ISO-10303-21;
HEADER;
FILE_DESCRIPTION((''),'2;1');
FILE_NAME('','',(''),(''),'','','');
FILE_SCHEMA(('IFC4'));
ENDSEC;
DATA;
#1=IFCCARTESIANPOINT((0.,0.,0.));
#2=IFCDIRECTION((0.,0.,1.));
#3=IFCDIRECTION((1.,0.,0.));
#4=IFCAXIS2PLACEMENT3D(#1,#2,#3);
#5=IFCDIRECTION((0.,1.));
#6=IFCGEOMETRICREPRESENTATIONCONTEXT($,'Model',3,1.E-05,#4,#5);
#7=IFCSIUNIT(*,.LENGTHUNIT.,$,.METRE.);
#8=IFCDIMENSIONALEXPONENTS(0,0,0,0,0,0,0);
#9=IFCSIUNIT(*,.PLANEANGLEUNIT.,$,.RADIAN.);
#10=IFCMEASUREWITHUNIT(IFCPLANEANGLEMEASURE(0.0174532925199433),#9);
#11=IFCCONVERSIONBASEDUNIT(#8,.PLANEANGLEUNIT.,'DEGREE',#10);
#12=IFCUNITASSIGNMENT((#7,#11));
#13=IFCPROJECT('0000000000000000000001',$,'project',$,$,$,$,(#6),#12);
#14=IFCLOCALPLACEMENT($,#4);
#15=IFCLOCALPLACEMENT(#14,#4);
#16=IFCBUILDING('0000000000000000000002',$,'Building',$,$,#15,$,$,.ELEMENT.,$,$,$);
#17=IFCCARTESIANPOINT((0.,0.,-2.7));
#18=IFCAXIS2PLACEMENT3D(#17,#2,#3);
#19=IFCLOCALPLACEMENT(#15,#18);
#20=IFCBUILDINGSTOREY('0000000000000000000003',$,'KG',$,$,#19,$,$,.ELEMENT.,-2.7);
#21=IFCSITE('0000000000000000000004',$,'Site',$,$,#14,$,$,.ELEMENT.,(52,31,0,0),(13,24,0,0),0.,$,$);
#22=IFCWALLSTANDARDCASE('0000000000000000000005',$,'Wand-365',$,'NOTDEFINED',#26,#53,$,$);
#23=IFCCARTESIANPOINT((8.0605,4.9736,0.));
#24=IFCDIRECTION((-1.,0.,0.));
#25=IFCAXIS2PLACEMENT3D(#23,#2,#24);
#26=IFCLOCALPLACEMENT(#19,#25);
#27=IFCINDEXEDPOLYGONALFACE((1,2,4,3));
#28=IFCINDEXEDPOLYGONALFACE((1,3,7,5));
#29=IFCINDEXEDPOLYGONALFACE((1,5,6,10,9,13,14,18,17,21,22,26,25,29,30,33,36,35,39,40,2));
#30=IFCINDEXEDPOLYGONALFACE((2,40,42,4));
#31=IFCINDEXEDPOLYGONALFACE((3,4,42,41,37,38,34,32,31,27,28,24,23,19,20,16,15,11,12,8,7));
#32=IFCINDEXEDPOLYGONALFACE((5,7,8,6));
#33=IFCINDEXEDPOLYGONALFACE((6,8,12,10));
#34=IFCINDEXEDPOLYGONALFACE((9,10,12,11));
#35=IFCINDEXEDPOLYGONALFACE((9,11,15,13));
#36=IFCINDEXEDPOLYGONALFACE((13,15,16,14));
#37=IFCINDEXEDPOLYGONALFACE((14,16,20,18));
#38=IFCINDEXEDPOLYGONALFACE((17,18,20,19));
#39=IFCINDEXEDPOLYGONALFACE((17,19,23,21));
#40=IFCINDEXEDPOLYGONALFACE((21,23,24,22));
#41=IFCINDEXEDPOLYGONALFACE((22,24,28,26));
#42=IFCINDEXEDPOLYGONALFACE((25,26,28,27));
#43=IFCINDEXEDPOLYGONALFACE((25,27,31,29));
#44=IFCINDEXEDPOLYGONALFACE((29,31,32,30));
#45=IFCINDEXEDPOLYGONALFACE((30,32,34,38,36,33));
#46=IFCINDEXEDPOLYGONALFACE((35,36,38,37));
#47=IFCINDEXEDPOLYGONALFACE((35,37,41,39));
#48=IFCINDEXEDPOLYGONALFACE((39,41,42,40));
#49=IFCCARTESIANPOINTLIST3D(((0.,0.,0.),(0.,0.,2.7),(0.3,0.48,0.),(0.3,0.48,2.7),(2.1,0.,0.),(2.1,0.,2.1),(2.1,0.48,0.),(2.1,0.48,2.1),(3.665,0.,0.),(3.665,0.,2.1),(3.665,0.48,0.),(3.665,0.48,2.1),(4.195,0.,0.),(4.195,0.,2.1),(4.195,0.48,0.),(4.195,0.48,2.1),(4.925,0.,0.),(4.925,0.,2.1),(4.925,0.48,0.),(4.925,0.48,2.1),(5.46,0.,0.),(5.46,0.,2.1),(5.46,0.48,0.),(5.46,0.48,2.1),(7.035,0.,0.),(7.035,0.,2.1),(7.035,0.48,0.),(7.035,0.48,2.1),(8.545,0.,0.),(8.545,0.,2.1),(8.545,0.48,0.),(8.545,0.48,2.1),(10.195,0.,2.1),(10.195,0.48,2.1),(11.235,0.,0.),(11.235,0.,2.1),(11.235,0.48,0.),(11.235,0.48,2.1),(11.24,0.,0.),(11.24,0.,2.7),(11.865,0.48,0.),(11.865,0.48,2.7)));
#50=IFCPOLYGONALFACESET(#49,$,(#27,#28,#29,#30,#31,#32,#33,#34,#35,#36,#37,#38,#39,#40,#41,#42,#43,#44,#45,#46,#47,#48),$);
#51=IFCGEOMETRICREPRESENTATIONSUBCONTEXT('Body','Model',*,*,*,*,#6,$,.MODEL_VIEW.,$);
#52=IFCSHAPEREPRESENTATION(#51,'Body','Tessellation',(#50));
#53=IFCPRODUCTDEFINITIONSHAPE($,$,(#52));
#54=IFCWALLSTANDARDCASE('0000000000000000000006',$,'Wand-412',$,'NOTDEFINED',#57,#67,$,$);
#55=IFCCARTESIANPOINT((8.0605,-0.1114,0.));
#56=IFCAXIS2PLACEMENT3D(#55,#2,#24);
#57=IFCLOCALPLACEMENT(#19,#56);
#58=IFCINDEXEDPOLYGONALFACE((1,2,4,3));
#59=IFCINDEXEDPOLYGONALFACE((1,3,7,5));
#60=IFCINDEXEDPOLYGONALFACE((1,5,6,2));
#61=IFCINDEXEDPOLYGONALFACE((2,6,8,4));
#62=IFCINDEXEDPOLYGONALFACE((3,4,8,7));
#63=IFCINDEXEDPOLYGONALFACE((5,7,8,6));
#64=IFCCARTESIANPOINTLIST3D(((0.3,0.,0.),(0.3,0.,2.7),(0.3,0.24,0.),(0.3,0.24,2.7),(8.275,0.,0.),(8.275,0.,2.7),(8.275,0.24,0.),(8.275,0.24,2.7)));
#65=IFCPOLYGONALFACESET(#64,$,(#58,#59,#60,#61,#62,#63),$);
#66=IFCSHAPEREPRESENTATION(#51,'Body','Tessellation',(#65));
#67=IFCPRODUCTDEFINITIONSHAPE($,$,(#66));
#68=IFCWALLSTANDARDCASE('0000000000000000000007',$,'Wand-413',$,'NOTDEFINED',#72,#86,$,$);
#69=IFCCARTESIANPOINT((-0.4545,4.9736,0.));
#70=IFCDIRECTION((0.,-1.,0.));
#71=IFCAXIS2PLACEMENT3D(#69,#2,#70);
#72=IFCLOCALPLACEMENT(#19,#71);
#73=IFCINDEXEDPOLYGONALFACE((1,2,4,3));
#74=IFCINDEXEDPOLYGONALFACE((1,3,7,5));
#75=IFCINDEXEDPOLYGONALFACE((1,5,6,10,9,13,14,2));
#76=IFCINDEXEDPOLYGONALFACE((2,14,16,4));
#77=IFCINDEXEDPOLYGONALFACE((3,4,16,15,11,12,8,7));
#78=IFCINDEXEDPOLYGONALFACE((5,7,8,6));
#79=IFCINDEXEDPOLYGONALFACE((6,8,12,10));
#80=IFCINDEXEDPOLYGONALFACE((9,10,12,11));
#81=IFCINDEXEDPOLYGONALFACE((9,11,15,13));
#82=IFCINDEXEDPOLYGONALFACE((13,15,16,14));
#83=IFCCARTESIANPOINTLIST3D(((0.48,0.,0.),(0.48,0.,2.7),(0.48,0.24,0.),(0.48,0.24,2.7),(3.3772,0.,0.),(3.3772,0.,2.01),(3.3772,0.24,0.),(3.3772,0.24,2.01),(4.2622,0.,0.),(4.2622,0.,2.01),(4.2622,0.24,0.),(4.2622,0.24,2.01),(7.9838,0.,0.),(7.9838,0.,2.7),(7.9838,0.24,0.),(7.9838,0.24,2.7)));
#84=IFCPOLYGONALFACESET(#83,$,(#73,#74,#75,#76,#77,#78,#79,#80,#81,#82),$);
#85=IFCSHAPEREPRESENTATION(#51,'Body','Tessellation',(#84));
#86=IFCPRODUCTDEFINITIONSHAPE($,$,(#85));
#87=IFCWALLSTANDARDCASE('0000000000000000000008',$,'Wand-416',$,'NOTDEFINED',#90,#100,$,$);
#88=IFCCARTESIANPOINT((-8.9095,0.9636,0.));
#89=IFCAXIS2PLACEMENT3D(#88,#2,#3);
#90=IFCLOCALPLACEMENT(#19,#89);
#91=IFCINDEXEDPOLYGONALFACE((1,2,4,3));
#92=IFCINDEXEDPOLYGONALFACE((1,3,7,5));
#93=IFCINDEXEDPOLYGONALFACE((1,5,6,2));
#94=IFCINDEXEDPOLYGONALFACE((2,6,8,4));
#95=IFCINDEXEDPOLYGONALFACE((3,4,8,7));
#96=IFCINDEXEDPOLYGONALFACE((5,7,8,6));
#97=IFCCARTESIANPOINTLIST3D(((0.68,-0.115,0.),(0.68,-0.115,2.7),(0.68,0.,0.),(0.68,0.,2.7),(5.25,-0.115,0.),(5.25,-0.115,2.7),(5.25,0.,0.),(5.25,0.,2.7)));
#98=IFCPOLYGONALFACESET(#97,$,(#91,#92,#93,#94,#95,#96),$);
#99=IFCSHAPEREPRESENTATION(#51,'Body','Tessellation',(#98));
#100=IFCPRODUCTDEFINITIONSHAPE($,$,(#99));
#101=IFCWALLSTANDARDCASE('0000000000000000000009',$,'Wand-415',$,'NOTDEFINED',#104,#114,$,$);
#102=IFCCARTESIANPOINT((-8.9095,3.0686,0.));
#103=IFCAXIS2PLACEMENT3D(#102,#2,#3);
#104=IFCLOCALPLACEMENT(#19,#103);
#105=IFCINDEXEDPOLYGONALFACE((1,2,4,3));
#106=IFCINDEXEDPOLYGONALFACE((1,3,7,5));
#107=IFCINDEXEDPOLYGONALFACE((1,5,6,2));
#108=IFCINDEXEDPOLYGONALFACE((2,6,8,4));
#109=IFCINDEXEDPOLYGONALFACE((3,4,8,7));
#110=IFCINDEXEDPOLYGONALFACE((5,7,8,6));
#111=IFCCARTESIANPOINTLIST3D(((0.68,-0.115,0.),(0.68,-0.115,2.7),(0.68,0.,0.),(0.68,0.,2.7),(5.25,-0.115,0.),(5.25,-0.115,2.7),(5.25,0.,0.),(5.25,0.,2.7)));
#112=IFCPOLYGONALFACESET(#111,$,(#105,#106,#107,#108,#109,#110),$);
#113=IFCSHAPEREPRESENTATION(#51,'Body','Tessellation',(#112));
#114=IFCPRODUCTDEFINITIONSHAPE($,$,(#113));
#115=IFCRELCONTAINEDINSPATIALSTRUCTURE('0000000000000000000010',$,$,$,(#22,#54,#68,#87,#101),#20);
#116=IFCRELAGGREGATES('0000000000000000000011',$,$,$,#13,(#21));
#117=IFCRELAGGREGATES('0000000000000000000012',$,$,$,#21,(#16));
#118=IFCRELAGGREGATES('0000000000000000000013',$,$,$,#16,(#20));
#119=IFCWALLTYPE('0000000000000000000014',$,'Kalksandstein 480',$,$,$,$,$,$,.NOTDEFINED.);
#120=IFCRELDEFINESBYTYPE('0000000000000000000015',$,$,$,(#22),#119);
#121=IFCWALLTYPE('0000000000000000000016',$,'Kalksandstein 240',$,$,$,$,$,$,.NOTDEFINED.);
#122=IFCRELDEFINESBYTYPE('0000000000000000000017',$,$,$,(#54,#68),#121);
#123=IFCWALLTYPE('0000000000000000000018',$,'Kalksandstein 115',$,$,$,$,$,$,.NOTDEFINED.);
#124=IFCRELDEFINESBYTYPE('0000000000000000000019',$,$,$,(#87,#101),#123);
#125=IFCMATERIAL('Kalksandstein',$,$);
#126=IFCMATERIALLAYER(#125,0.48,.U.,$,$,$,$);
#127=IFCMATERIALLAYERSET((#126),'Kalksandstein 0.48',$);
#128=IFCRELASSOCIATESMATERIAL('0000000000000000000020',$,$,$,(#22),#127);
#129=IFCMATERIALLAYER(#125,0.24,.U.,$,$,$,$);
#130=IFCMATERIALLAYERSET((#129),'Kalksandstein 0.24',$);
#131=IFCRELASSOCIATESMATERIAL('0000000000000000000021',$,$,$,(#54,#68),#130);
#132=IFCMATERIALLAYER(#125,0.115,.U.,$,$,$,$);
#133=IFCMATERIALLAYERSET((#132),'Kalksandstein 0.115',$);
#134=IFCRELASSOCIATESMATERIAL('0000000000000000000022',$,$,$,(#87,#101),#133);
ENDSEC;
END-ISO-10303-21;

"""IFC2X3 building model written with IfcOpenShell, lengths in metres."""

from ifc_helpers import new_model, entity, si_unit, converted_unit, direction, frame, origin_with_axes, origin_2d_with_axis, place, context, subcontext, project, spatial, polyline, rectangle, outline, extrude, material, layer, layer_set, layer_usage, type_object, element, save


model = new_model("IFC2X3")

# Units and contexts
model_context = context("Model", 3, precision=1e-05, world=origin_with_axes(), true_north=direction((0.0, 1.0)))
body_context = subcontext(model_context, "Body", "Model", "MODEL_VIEW")
ifc_project = project(units=[si_unit("LENGTHUNIT", "METRE"), converted_unit("PLANEANGLEUNIT", "DEGREE", entity("IfcPlaneAngleMeasure", 0.0174532925199433), si_unit("PLANEANGLEUNIT", "RADIAN"), dimensions=[0, 0, 0, 0, 0, 0, 0])], contexts=[model_context])

# Site, building, storey
site_placement = place(None, origin_with_axes())
site = spatial("IfcSite", under=ifc_project, at=site_placement, Name="Site", CompositionType="ELEMENT", RefLatitude=(52, 31, 0, 0), RefLongitude=(13, 24, 0, 0), RefElevation=0.0)
building_placement = place(site_placement, origin_with_axes())
building = spatial("IfcBuilding", under=site, at=building_placement, Name="Building", CompositionType="ELEMENT")
storey_placement = place(building_placement, frame((0.0, 0.0, -2.7), z_axis=(0.0, 0.0, 1.0), x_axis=(1.0, 0.0, 0.0)))
storey = spatial("IfcBuildingStorey", under=building, at=storey_placement, Name="KG", CompositionType="ELEMENT", Elevation=-2.7)

# Shared definitions
ifc_material_1 = material(Name="Kalksandstein")

# Wall, openings
ifc_layer_1 = layer(ifc_material_1, 0.48, ventilated="UNKNOWN")
ifc_layer_set_1 = layer_set([ifc_layer_1], Name="Kalksandstein 0.48")
ifc_layer_usage_1 = layer_usage(ifc_layer_set_1, "AXIS2", "POSITIVE", 0.0)
wall_type_1 = type_object("IfcWallType", Name="Kalksandstein 480", PredefinedType="NOTDEFINED")
wall_1_placement = place(storey_placement, frame((8.0605, 4.9736, 0.0), z_axis=(0.0, 0.0, 1.0), x_axis=(-1.0, 0.0, 0.0)))
wall_1 = element("IfcWallStandardCase", 1, at=wall_1_placement, inside=storey, type_object=wall_type_1, material=ifc_layer_usage_1, Name="Wand-365", ObjectType="NOTDEFINED", context=body_context, shape_type="SweptSolid", body=[
    extrude(outline(polyline([(0.0, 0.0), (11.24, 0.0), (11.865, 0.48), (0.3, 0.48), (0.0, 0.0)])), origin_with_axes(), (0.0, 0.0, 1.0), 2.7),
])
opening_1_placement = place(wall_1_placement, frame((2.8825, 0.0, 0.0), z_axis=(0.0, 0.0, 1.0), x_axis=(1.0, 0.0, 0.0)))
element("IfcOpeningElement", 2, at=opening_1_placement, cuts=wall_1, context=body_context, shape_type="SweptSolid", body=[
    extrude(rectangle(XDim=1.565, YDim=2.1, at=origin_2d_with_axis()), frame((0.0, 0.48, 1.05), z_axis=(0.0, -1.0, 0.0), x_axis=(-1.0, 0.0, 0.0)), (0.0, 0.0, 1.0), 1.44),
])
opening_2_placement = place(wall_1_placement, frame((10.715, 0.0, 0.0), z_axis=(0.0, 0.0, 1.0), x_axis=(1.0, 0.0, 0.0)))
element("IfcOpeningElement", 3, at=opening_2_placement, cuts=wall_1, context=body_context, shape_type="SweptSolid", body=[
    extrude(rectangle(XDim=1.04, YDim=2.1, at=origin_2d_with_axis()), frame((0.0, 0.48, 1.05), z_axis=(0.0, -1.0, 0.0), x_axis=(-1.0, 0.0, 0.0)), (0.0, 0.0, 1.0), 1.44),
])
opening_3_placement = place(wall_1_placement, frame((6.2475, 0.0, 0.0), z_axis=(0.0, 0.0, 1.0), x_axis=(1.0, 0.0, 0.0)))
element("IfcOpeningElement", 4, at=opening_3_placement, cuts=wall_1, context=body_context, shape_type="SweptSolid", body=[
    extrude(rectangle(XDim=1.575, YDim=2.1, at=origin_2d_with_axis()), frame((0.0, 0.48, 1.05), z_axis=(0.0, -1.0, 0.0), x_axis=(-1.0, 0.0, 0.0)), (0.0, 0.0, 1.0), 1.44),
])
opening_4_placement = place(wall_1_placement, frame((4.56, 0.0, 0.0), z_axis=(0.0, 0.0, 1.0), x_axis=(1.0, 0.0, 0.0)))
element("IfcOpeningElement", 5, at=opening_4_placement, cuts=wall_1, context=body_context, shape_type="SweptSolid", body=[
    extrude(rectangle(XDim=0.73, YDim=2.1, at=origin_2d_with_axis()), frame((0.0, 0.48, 1.05), z_axis=(0.0, -1.0, 0.0), x_axis=(-1.0, 0.0, 0.0)), (0.0, 0.0, 1.0), 1.44),
])
opening_5_placement = place(wall_1_placement, frame((9.37, 0.0, 0.0), z_axis=(0.0, 0.0, 1.0), x_axis=(1.0, 0.0, 0.0)))
element("IfcOpeningElement", 6, at=opening_5_placement, cuts=wall_1, context=body_context, shape_type="SweptSolid", body=[
    extrude(rectangle(XDim=1.65, YDim=2.1, at=origin_2d_with_axis()), frame((0.0, 0.48, 1.05), z_axis=(0.0, 1.0, 0.0), x_axis=(-1.0, 0.0, 0.0)), (0.0, 0.0, -1.0), 1.44),
])

# Wall
ifc_layer_2 = layer(ifc_material_1, 0.24, ventilated="UNKNOWN")
ifc_layer_set_2 = layer_set([ifc_layer_2], Name="Kalksandstein 0.24")
ifc_layer_usage_2 = layer_usage(ifc_layer_set_2, "AXIS2", "POSITIVE", 0.0)
wall_type_2 = type_object("IfcWallType", Name="Kalksandstein 240", PredefinedType="NOTDEFINED")
wall_2_placement = place(storey_placement, frame((8.0605, -0.1114, 0.0), z_axis=(0.0, 0.0, 1.0), x_axis=(-1.0, 0.0, 0.0)))
element("IfcWallStandardCase", 7, at=wall_2_placement, inside=storey, type_object=wall_type_2, material=ifc_layer_usage_2, Name="Wand-412", ObjectType="NOTDEFINED", context=body_context, shape_type="SweptSolid", body=[
    extrude(outline(polyline([(0.3, 0.0), (8.275, 0.0), (8.275, 0.24), (0.3, 0.24), (0.3, 0.0)])), origin_with_axes(), (0.0, 0.0, 1.0), 2.7),
])

# Wall, opening
ifc_layer_usage_3 = layer_usage(ifc_layer_set_2, "AXIS2", "POSITIVE", 0.0)
wall_3_placement = place(storey_placement, frame((-0.4545, 4.9736, 0.0), z_axis=(0.0, 0.0, 1.0), x_axis=(0.0, -1.0, 0.0)))
wall_3 = element("IfcWallStandardCase", 8, at=wall_3_placement, inside=storey, type_object=wall_type_2, material=ifc_layer_usage_3, Name="Wand-413", ObjectType="NOTDEFINED", context=body_context, shape_type="SweptSolid", body=[
    extrude(outline(polyline([(0.48, 0.0), (7.9838, 0.0), (7.9838, 0.24), (0.48, 0.24), (0.48, 0.0)])), origin_with_axes(), (0.0, 0.0, 1.0), 2.7),
])
opening_6_placement = place(wall_3_placement, frame((3.8197, 0.0, 0.0), z_axis=(0.0, 0.0, 1.0), x_axis=(1.0, 0.0, 0.0)))
element("IfcOpeningElement", 9, at=opening_6_placement, cuts=wall_3, context=body_context, shape_type="SweptSolid", body=[
    extrude(rectangle(XDim=0.885, YDim=2.01, at=origin_2d_with_axis()), frame((0.0, -0.24, 1.005), z_axis=(0.0, 1.0, 0.0), x_axis=(1.0, 0.0, 0.0)), (0.0, 0.0, 1.0), 0.72),
])

# Walls
ifc_layer_3 = layer(ifc_material_1, 0.115, ventilated="UNKNOWN")
ifc_layer_set_3 = layer_set([ifc_layer_3], Name="Kalksandstein 0.115")
ifc_layer_usage_4 = layer_usage(ifc_layer_set_3, "AXIS2", "NEGATIVE", 0.0)
wall_type_3 = type_object("IfcWallType", Name="Kalksandstein 115", PredefinedType="NOTDEFINED")
wall_4_placement = place(storey_placement, frame((-8.9095, 0.9636, 0.0), z_axis=(0.0, 0.0, 1.0), x_axis=(1.0, 0.0, 0.0)))
element("IfcWallStandardCase", 10, at=wall_4_placement, inside=storey, type_object=wall_type_3, material=ifc_layer_usage_4, Name="Wand-416", ObjectType="NOTDEFINED", context=body_context, shape_type="SweptSolid", body=[
    extrude(outline(polyline([(0.68, -0.115), (5.25, -0.115), (5.25, 0.0), (0.68, 0.0), (0.68, -0.115)])), origin_with_axes(), (0.0, 0.0, 1.0), 2.7),
])
ifc_layer_usage_5 = layer_usage(ifc_layer_set_3, "AXIS2", "NEGATIVE", 0.0)
wall_5_placement = place(storey_placement, frame((-8.9095, 3.0686, 0.0), z_axis=(0.0, 0.0, 1.0), x_axis=(1.0, 0.0, 0.0)))
element("IfcWallStandardCase", 11, at=wall_5_placement, inside=storey, type_object=wall_type_3, material=ifc_layer_usage_5, Name="Wand-415", ObjectType="NOTDEFINED", context=body_context, shape_type="SweptSolid", body=[
    extrude(outline(polyline([(0.68, -0.115), (5.25, -0.115), (5.25, 0.0), (0.68, 0.0), (0.68, -0.115)])), origin_with_axes(), (0.0, 0.0, 1.0), 2.7),
])

save(model, "model.ifc")
